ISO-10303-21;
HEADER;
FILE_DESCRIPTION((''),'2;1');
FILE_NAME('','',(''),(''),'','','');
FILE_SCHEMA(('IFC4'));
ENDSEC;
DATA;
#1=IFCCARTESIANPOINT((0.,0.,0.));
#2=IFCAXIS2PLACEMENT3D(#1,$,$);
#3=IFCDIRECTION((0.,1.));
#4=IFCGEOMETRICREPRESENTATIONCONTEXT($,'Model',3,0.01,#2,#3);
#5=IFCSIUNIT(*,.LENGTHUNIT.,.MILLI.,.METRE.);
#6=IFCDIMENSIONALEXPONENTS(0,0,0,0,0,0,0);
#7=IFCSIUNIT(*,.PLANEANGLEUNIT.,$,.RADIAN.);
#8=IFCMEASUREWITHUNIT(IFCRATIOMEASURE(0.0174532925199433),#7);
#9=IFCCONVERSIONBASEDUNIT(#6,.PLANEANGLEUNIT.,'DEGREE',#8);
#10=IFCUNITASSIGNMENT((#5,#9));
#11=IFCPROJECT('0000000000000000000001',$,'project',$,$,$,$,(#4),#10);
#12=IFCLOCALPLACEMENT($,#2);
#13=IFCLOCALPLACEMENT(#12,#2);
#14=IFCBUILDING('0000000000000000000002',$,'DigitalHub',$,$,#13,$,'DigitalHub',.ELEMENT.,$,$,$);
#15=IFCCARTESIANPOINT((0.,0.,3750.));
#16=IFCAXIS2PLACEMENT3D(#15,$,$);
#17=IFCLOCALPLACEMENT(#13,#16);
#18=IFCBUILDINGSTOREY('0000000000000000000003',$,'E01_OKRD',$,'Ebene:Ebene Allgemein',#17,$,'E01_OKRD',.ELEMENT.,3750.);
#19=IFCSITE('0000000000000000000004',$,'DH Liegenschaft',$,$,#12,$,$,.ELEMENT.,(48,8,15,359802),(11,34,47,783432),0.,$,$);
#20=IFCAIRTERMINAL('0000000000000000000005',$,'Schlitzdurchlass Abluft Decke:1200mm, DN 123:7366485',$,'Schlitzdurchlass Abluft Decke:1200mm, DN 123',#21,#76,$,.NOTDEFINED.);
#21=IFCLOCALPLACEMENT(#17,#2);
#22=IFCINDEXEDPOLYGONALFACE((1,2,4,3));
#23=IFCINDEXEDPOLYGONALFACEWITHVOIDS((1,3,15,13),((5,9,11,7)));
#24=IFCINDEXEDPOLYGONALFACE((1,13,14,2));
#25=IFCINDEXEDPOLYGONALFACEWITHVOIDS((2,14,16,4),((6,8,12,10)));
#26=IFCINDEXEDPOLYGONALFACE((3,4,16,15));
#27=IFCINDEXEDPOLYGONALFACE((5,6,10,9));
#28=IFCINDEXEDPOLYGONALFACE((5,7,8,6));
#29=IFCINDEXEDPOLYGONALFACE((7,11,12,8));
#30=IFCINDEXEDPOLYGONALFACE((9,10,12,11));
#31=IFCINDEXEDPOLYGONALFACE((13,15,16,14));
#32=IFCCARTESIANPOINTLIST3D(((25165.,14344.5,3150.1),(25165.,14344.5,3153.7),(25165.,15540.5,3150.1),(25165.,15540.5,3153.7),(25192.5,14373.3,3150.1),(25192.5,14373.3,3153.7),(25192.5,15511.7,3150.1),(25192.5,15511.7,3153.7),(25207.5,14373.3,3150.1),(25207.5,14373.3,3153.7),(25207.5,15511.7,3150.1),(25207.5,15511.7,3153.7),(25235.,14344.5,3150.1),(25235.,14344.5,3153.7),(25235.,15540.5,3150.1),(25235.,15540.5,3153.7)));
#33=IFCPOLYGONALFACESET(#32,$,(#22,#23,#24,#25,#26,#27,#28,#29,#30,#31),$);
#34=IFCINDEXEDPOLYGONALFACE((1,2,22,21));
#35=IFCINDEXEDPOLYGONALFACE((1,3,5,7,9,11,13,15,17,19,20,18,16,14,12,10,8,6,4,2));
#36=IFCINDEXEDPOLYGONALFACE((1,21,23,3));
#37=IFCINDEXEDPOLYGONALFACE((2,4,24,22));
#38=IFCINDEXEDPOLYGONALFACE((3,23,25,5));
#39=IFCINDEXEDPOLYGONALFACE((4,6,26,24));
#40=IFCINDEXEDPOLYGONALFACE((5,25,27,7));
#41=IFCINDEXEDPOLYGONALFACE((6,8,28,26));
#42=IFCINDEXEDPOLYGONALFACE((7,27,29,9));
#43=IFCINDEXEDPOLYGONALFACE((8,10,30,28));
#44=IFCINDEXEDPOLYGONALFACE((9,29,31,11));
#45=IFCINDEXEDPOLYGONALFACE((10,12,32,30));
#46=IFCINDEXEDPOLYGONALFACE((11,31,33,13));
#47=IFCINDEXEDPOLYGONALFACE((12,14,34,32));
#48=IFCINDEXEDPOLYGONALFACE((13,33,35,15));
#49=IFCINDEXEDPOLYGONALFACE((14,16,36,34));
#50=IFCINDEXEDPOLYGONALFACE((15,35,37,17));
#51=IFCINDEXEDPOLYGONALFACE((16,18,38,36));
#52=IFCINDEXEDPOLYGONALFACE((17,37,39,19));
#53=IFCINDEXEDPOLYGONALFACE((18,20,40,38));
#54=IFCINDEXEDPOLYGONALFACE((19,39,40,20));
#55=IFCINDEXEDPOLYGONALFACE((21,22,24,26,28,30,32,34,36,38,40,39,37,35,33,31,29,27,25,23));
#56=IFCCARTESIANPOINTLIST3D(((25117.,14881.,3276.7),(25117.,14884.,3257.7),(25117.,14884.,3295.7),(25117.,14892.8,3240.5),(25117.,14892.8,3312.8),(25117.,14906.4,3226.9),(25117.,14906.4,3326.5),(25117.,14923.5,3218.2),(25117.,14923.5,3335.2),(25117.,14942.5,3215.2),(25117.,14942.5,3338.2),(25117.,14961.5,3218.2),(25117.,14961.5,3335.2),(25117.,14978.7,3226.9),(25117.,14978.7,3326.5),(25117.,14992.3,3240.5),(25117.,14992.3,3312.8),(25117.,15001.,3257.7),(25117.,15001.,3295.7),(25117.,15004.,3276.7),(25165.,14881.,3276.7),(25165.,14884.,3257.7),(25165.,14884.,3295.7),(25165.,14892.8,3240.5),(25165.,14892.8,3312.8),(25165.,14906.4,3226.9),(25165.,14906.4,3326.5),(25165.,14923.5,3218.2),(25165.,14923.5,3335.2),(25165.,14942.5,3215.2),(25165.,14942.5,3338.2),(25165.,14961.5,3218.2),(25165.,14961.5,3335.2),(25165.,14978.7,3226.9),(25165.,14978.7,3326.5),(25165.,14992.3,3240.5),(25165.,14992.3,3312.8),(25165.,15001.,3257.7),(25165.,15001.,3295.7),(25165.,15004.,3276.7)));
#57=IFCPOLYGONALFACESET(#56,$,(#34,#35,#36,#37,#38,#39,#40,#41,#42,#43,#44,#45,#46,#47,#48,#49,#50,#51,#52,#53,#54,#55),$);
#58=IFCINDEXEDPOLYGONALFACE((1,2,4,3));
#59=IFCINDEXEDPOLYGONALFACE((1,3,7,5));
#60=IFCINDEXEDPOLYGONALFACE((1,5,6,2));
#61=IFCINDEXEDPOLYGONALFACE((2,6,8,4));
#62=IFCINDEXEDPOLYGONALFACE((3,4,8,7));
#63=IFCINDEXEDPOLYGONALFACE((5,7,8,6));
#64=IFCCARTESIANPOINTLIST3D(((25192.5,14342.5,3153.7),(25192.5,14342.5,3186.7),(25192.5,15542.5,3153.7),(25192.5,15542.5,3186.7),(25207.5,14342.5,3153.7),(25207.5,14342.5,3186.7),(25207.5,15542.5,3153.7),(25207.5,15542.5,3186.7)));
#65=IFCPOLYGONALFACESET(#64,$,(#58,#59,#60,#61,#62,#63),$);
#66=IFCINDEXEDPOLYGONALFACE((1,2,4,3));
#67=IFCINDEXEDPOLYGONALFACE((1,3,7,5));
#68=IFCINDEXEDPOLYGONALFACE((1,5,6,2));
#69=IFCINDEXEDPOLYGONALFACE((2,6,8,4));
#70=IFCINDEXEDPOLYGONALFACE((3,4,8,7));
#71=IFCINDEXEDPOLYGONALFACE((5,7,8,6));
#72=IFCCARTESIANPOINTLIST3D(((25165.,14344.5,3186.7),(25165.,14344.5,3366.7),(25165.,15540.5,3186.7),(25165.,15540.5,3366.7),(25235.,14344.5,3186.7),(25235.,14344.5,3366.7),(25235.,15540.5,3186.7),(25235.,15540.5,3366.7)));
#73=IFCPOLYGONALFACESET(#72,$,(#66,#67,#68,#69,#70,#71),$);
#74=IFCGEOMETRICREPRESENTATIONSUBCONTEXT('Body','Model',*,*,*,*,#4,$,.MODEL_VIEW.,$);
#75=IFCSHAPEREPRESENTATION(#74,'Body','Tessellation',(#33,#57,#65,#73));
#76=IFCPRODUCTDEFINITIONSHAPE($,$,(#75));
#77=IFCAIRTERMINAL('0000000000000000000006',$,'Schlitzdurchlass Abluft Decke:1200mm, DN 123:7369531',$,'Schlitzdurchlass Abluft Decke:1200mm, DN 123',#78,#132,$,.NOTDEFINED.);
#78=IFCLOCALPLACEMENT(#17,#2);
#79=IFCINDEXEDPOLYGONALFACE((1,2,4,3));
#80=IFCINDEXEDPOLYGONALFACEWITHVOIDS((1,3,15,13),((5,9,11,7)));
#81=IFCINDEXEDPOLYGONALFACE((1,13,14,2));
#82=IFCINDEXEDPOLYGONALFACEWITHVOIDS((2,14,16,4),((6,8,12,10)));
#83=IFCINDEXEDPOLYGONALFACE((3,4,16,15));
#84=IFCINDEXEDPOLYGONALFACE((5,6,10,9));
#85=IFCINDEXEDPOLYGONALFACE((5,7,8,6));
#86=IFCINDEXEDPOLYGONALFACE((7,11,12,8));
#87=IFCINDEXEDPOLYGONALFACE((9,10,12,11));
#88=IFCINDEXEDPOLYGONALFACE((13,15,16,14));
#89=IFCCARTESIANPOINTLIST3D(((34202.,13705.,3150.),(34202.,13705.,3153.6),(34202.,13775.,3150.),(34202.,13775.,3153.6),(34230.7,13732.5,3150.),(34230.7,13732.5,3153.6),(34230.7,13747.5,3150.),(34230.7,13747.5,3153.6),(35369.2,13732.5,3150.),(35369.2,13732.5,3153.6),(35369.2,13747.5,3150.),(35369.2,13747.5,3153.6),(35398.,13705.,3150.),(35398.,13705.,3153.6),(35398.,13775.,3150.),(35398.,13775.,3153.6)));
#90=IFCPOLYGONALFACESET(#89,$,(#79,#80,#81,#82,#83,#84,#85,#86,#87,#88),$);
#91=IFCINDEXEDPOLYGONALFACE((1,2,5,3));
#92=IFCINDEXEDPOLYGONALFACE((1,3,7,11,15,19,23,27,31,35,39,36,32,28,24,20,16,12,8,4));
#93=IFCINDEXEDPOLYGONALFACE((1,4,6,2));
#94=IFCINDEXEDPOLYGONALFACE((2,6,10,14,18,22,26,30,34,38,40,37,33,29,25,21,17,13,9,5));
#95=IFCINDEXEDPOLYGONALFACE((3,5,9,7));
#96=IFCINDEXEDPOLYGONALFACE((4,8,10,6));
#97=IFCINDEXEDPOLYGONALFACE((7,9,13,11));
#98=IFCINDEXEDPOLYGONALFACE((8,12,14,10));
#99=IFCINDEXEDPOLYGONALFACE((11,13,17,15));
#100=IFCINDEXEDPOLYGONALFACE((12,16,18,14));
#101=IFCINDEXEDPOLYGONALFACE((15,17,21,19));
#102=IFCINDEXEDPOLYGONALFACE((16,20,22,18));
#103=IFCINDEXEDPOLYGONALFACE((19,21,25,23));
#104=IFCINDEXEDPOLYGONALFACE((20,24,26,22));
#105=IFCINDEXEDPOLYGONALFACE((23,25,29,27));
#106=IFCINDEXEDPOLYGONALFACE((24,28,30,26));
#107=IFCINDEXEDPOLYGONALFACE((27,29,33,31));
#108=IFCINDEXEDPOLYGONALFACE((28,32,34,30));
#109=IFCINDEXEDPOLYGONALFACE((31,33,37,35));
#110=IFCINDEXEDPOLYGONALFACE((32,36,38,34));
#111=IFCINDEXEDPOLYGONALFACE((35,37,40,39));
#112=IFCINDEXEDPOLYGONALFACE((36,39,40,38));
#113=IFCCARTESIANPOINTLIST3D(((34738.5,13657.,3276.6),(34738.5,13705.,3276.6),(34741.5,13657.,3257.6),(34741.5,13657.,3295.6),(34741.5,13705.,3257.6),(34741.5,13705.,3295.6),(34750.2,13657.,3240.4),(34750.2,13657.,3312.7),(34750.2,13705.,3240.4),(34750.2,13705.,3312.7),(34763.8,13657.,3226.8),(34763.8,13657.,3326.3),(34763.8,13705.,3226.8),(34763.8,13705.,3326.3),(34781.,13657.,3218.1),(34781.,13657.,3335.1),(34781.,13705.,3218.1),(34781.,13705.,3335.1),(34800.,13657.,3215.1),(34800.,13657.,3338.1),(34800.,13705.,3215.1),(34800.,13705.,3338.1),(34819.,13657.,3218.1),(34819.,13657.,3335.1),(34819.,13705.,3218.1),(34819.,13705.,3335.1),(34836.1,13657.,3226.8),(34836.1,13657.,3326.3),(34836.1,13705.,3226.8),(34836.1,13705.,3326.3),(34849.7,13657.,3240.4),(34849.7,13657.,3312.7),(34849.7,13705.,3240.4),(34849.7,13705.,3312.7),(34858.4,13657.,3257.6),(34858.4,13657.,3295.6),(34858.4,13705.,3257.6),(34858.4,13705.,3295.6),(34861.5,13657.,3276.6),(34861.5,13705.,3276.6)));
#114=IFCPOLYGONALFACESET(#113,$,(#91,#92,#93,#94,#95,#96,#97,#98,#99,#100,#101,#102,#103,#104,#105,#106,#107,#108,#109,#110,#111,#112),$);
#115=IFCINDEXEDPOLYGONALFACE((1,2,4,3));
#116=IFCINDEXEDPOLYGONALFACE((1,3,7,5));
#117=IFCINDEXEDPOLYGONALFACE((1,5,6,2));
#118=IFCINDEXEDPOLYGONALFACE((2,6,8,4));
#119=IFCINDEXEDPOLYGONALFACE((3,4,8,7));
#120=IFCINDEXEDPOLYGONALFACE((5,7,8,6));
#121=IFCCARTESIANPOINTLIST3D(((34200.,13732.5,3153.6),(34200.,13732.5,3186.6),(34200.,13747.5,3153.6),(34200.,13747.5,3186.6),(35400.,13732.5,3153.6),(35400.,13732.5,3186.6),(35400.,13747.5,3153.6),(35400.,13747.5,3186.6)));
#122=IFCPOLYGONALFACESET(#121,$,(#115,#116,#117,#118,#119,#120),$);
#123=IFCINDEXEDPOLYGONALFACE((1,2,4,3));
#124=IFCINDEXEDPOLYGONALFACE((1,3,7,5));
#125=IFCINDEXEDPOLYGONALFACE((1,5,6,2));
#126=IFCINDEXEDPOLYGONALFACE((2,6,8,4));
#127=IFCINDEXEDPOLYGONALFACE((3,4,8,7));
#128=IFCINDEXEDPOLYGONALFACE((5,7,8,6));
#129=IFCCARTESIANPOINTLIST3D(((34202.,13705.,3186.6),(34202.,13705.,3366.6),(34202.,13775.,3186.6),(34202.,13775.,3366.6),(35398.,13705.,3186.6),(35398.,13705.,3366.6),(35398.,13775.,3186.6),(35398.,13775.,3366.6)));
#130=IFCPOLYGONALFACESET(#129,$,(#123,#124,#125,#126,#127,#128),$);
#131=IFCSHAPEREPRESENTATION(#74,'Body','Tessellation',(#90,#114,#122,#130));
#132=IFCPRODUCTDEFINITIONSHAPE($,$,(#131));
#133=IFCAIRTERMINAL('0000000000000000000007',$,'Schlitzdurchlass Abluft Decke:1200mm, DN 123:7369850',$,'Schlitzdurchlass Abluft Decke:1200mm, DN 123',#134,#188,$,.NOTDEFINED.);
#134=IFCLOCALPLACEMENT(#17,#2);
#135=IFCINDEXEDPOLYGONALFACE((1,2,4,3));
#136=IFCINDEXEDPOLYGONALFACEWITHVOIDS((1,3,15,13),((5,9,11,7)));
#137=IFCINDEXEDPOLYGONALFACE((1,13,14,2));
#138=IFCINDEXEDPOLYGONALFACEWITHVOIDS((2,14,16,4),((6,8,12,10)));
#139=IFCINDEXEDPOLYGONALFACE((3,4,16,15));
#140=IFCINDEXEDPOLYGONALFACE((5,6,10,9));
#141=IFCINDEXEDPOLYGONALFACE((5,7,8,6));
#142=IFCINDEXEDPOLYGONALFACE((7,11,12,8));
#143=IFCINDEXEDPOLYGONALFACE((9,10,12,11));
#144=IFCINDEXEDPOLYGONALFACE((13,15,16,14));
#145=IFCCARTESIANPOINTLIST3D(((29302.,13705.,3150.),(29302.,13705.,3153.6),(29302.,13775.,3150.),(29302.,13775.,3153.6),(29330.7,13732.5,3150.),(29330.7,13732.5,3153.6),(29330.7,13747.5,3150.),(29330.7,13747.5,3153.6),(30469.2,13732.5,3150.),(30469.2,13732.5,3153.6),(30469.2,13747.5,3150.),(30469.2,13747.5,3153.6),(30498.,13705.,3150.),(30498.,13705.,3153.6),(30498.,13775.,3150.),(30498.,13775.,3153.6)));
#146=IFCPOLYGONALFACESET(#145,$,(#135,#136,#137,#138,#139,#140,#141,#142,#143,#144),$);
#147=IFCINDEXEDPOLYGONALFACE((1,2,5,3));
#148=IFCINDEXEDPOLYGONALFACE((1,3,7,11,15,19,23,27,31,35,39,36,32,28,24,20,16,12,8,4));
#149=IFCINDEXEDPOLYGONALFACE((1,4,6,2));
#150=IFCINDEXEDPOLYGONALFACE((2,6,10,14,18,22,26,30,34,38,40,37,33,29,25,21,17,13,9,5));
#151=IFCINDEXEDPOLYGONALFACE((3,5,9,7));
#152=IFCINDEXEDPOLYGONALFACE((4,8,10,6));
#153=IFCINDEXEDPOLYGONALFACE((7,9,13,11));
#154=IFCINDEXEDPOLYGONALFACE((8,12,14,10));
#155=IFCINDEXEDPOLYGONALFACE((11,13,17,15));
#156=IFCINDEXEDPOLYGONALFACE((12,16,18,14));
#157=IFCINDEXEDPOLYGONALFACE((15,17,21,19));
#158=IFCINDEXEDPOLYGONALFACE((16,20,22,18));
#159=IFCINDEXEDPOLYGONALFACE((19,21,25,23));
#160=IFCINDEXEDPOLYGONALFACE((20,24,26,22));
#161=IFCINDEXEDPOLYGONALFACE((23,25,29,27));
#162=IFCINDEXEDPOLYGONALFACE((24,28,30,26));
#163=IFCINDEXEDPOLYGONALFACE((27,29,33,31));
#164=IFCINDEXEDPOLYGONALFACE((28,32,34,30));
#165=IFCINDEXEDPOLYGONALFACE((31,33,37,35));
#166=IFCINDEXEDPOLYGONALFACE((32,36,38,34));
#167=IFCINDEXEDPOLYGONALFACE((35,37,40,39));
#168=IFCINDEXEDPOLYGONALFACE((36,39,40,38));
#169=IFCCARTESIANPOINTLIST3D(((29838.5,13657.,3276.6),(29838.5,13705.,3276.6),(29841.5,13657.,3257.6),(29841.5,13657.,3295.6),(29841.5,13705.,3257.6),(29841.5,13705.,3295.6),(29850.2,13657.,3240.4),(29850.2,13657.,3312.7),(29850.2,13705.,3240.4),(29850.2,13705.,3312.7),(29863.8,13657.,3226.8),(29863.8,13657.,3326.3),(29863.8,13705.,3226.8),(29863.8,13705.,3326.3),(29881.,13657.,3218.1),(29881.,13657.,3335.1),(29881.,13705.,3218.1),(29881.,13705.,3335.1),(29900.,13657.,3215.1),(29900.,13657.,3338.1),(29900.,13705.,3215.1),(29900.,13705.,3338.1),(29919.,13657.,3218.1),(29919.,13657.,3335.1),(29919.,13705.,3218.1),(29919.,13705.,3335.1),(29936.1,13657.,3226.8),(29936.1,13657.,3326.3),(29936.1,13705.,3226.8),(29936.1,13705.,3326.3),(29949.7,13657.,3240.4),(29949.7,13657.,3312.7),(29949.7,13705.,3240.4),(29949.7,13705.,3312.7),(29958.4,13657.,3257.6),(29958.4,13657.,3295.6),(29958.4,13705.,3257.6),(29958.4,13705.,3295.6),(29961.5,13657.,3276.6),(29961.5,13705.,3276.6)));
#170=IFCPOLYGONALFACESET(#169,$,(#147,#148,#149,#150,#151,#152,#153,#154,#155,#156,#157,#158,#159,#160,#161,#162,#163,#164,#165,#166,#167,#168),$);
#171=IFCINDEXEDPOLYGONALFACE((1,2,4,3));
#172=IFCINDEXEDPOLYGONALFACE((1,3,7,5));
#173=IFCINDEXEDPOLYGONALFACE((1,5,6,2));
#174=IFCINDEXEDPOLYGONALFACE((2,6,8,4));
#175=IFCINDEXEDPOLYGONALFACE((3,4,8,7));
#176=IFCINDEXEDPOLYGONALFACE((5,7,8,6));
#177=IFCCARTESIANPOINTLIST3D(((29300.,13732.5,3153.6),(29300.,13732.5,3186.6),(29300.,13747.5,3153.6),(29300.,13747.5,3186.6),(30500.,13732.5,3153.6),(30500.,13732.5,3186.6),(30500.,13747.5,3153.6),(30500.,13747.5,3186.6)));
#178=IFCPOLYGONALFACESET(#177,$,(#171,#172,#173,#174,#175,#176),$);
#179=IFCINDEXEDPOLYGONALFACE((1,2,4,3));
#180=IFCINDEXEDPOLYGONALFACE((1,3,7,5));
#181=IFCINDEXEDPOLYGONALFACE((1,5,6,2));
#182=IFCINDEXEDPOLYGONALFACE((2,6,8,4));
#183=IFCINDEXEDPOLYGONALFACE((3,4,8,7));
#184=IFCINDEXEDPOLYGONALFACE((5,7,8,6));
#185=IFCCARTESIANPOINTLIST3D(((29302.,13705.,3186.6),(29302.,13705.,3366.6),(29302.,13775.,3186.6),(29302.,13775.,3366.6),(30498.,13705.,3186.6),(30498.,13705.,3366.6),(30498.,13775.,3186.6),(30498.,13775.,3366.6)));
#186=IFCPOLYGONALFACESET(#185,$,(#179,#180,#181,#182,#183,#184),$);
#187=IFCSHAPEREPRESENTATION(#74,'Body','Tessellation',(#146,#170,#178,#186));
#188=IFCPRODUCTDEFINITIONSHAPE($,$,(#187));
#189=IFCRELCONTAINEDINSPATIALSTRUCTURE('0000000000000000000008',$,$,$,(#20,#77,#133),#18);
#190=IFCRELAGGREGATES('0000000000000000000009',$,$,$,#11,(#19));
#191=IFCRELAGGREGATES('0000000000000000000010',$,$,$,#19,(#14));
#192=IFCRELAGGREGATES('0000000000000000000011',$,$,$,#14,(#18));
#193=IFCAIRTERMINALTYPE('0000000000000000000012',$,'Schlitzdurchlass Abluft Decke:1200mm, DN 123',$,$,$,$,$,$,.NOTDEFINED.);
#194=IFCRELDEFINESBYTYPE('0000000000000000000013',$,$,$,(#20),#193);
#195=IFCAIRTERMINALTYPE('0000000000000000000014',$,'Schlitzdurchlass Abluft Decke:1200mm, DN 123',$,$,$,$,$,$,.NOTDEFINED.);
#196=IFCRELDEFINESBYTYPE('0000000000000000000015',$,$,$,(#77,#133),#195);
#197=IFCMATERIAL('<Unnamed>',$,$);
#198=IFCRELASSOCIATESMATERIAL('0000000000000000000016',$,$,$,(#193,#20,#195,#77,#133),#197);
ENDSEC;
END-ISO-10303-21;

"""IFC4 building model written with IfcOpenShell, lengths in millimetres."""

from ifc_helpers import new_model, entity, si_unit, converted_unit, direction, frame, origin, place, context, subcontext, project, spatial, indexed_curve, outline, extrude, source, transform, mapped, material, type_object, type_shapes, element, save


model = new_model("IFC4")

# Units and contexts
model_context = context("Model", 3, precision=0.01, world=origin(), true_north=direction((0.0, 1.0)))
body_context = subcontext(model_context, "Body", "Model", "MODEL_VIEW")
ifc_project = project(units=[si_unit("LENGTHUNIT", "METRE", prefix="MILLI"), converted_unit("PLANEANGLEUNIT", "DEGREE", entity("IfcRatioMeasure", 0.0174532925199433), si_unit("PLANEANGLEUNIT", "RADIAN"), dimensions=[0, 0, 0, 0, 0, 0, 0])], contexts=[model_context])

# Site, building, storey
site_placement = place(None, origin())
site = spatial("IfcSite", under=ifc_project, at=site_placement, Name="DH Liegenschaft", CompositionType="ELEMENT", RefLatitude=(48, 8, 15, 359802), RefLongitude=(11, 34, 47, 783432), RefElevation=0.0)
building_placement = place(site_placement, origin())
building = spatial("IfcBuilding", under=site, at=building_placement, Name="DigitalHub", LongName="DigitalHub", CompositionType="ELEMENT")
storey_placement = place(building_placement, frame((0.0, 0.0, 3750.0)))
storey = spatial("IfcBuildingStorey", under=building, at=storey_placement, Name="E01_OKRD", ObjectType="Ebene:Ebene Allgemein", LongName="E01_OKRD", CompositionType="ELEMENT", Elevation=3750.0)

# Shared definitions
ifc_material_1 = material(Name="<Unnamed>")

# Air terminals
air_terminal_type_1 = type_object("IfcAirTerminalType", Name="Schlitzdurchlass Abluft Decke:1200mm, DN 123", PredefinedType="NOTDEFINED", material=ifc_material_1)
shared_shape_1 = source(origin(), body_context, "Body", "SweptSolid", [
    extrude(outline(indexed_curve([(-598.0, -35.0), (598.0, -35.0), (598.0, 35.0), (-598.0, 35.0), (-598.0, -35.0)], self_intersect=False), holes=[indexed_curve([(-569.2, -7.5), (-569.2, 7.5), (569.2, 7.5), (569.2, -7.5), (-569.2, -7.5)], self_intersect=False)]), frame((0.0, 0.0, 0.0), z_axis=(0.0, 0.0, 1.0), x_axis=(-1.0, 0.0, 0.0)), (0.0, 0.0, 1.0), 3.6),
    extrude(outline(indexed_curve([(61.5, 0.0), (58.5, 19.0), (49.8, 36.1), (36.1, 49.8), (19.0, 58.5), (0.0, 61.5), (-19.0, 58.5), (-36.1, 49.8), (-49.8, 36.1), (-58.5, 19.0), (-61.5, 0.0), (-58.5, -19.0), (-49.8, -36.1), (-36.1, -49.8), (-19.0, -58.5), (0.0, -61.5), (19.0, -58.5), (36.1, -49.8), (49.8, -36.1), (58.5, -19.0), (61.5, 0.0)], self_intersect=False)), frame((0.0, 35.0, 126.6), z_axis=(0.0, 1.0, 0.0), x_axis=(-1.0, 0.0, 0.0)), (0.0, 0.0, 1.0), 48.0),
    extrude(outline(indexed_curve([(-600.0, -7.5), (600.0, -7.5), (600.0, 7.5), (-600.0, 7.5), (-600.0, -7.5)], self_intersect=False)), frame((0.0, 0.0, 3.6), z_axis=(0.0, 0.0, 1.0), x_axis=(-1.0, 0.0, 0.0)), (0.0, 0.0, 1.0), 33.0),
    extrude(outline(indexed_curve([(-598.0, -35.0), (598.0, -35.0), (598.0, 35.0), (-598.0, 35.0), (-598.0, -35.0)], self_intersect=False)), frame((0.0, 0.0, 36.6), z_axis=(0.0, 0.0, 1.0), x_axis=(-1.0, 0.0, 0.0)), (0.0, 0.0, 1.0), 180.0),
])
type_shapes(air_terminal_type_1, [shared_shape_1])
for number, where, z_axis, x_axis, name in (
    (1, (25200.0, 14942.5, 3150.1), (0.0, 0.0, 1.0), (0.0, 1.0, 0.0), "Schlitzdurchlass Abluft Decke:1200mm, DN 123:7366485"),
):
    element("IfcAirTerminal", number, at=place(storey_placement, frame(where, z_axis=z_axis, x_axis=x_axis)), inside=storey, type_object=air_terminal_type_1, material=ifc_material_1, Name=name, ObjectType="Schlitzdurchlass Abluft Decke:1200mm, DN 123", PredefinedType="NOTDEFINED", context=body_context, shape_type="MappedRepresentation", body=[
        mapped(shared_shape_1, transform((0.0, 0.0, 0.0), scale=1.0)),
    ])
air_terminal_type_2 = type_object("IfcAirTerminalType", Name="Schlitzdurchlass Abluft Decke:1200mm, DN 123", PredefinedType="NOTDEFINED", material=ifc_material_1)
shared_shape_2 = source(origin(), body_context, "Body", "SweptSolid", [
    extrude(outline(indexed_curve([(-598.0, -35.0), (598.0, -35.0), (598.0, 35.0), (-598.0, 35.0), (-598.0, -35.0)], self_intersect=False), holes=[indexed_curve([(-569.2, -7.5), (-569.2, 7.5), (569.2, 7.5), (569.2, -7.5), (-569.2, -7.5)], self_intersect=False)]), frame((0.0, 0.0, 0.0), z_axis=(0.0, 0.0, 1.0), x_axis=(-1.0, 0.0, 0.0)), (0.0, 0.0, 1.0), 3.6),
    extrude(outline(indexed_curve([(61.5, 0.0), (58.5, 19.0), (49.8, 36.1), (36.1, 49.8), (19.0, 58.5), (0.0, 61.5), (-19.0, 58.5), (-36.1, 49.8), (-49.8, 36.1), (-58.5, 19.0), (-61.5, 0.0), (-58.5, -19.0), (-49.8, -36.1), (-36.1, -49.8), (-19.0, -58.5), (0.0, -61.5), (19.0, -58.5), (36.1, -49.8), (49.8, -36.1), (58.5, -19.0), (61.5, 0.0)], self_intersect=False)), frame((0.0, 35.0, 126.6), z_axis=(0.0, 1.0, 0.0), x_axis=(-1.0, 0.0, 0.0)), (0.0, 0.0, 1.0), 48.0),
    extrude(outline(indexed_curve([(-600.0, -7.5), (600.0, -7.5), (600.0, 7.5), (-600.0, 7.5), (-600.0, -7.5)], self_intersect=False)), frame((0.0, 0.0, 3.6), z_axis=(0.0, 0.0, 1.0), x_axis=(-1.0, 0.0, 0.0)), (0.0, 0.0, 1.0), 33.0),
    extrude(outline(indexed_curve([(-598.0, -35.0), (598.0, -35.0), (598.0, 35.0), (-598.0, 35.0), (-598.0, -35.0)], self_intersect=False)), frame((0.0, 0.0, 36.6), z_axis=(0.0, 0.0, 1.0), x_axis=(-1.0, 0.0, 0.0)), (0.0, 0.0, 1.0), 180.0),
])
type_shapes(air_terminal_type_2, [shared_shape_2])
for number, where, z_axis, x_axis, name in (
    (2, (34800.0, 13740.0, 3150.0), (0.0, 0.0, 1.0), (-1.0, 0.0, 0.0), "Schlitzdurchlass Abluft Decke:1200mm, DN 123:7369531"),
    (3, (29900.0, 13740.0, 3150.0), (0.0, 0.0, 1.0), (-1.0, 0.0, 0.0), "Schlitzdurchlass Abluft Decke:1200mm, DN 123:7369850"),
):
    element("IfcAirTerminal", number, at=place(storey_placement, frame(where, z_axis=z_axis, x_axis=x_axis)), inside=storey, type_object=air_terminal_type_2, material=ifc_material_1, Name=name, ObjectType="Schlitzdurchlass Abluft Decke:1200mm, DN 123", PredefinedType="NOTDEFINED", context=body_context, shape_type="MappedRepresentation", body=[
        mapped(shared_shape_2, transform((0.0, 0.0, 0.0), scale=1.0)),
    ])

save(model, "model.ifc")
